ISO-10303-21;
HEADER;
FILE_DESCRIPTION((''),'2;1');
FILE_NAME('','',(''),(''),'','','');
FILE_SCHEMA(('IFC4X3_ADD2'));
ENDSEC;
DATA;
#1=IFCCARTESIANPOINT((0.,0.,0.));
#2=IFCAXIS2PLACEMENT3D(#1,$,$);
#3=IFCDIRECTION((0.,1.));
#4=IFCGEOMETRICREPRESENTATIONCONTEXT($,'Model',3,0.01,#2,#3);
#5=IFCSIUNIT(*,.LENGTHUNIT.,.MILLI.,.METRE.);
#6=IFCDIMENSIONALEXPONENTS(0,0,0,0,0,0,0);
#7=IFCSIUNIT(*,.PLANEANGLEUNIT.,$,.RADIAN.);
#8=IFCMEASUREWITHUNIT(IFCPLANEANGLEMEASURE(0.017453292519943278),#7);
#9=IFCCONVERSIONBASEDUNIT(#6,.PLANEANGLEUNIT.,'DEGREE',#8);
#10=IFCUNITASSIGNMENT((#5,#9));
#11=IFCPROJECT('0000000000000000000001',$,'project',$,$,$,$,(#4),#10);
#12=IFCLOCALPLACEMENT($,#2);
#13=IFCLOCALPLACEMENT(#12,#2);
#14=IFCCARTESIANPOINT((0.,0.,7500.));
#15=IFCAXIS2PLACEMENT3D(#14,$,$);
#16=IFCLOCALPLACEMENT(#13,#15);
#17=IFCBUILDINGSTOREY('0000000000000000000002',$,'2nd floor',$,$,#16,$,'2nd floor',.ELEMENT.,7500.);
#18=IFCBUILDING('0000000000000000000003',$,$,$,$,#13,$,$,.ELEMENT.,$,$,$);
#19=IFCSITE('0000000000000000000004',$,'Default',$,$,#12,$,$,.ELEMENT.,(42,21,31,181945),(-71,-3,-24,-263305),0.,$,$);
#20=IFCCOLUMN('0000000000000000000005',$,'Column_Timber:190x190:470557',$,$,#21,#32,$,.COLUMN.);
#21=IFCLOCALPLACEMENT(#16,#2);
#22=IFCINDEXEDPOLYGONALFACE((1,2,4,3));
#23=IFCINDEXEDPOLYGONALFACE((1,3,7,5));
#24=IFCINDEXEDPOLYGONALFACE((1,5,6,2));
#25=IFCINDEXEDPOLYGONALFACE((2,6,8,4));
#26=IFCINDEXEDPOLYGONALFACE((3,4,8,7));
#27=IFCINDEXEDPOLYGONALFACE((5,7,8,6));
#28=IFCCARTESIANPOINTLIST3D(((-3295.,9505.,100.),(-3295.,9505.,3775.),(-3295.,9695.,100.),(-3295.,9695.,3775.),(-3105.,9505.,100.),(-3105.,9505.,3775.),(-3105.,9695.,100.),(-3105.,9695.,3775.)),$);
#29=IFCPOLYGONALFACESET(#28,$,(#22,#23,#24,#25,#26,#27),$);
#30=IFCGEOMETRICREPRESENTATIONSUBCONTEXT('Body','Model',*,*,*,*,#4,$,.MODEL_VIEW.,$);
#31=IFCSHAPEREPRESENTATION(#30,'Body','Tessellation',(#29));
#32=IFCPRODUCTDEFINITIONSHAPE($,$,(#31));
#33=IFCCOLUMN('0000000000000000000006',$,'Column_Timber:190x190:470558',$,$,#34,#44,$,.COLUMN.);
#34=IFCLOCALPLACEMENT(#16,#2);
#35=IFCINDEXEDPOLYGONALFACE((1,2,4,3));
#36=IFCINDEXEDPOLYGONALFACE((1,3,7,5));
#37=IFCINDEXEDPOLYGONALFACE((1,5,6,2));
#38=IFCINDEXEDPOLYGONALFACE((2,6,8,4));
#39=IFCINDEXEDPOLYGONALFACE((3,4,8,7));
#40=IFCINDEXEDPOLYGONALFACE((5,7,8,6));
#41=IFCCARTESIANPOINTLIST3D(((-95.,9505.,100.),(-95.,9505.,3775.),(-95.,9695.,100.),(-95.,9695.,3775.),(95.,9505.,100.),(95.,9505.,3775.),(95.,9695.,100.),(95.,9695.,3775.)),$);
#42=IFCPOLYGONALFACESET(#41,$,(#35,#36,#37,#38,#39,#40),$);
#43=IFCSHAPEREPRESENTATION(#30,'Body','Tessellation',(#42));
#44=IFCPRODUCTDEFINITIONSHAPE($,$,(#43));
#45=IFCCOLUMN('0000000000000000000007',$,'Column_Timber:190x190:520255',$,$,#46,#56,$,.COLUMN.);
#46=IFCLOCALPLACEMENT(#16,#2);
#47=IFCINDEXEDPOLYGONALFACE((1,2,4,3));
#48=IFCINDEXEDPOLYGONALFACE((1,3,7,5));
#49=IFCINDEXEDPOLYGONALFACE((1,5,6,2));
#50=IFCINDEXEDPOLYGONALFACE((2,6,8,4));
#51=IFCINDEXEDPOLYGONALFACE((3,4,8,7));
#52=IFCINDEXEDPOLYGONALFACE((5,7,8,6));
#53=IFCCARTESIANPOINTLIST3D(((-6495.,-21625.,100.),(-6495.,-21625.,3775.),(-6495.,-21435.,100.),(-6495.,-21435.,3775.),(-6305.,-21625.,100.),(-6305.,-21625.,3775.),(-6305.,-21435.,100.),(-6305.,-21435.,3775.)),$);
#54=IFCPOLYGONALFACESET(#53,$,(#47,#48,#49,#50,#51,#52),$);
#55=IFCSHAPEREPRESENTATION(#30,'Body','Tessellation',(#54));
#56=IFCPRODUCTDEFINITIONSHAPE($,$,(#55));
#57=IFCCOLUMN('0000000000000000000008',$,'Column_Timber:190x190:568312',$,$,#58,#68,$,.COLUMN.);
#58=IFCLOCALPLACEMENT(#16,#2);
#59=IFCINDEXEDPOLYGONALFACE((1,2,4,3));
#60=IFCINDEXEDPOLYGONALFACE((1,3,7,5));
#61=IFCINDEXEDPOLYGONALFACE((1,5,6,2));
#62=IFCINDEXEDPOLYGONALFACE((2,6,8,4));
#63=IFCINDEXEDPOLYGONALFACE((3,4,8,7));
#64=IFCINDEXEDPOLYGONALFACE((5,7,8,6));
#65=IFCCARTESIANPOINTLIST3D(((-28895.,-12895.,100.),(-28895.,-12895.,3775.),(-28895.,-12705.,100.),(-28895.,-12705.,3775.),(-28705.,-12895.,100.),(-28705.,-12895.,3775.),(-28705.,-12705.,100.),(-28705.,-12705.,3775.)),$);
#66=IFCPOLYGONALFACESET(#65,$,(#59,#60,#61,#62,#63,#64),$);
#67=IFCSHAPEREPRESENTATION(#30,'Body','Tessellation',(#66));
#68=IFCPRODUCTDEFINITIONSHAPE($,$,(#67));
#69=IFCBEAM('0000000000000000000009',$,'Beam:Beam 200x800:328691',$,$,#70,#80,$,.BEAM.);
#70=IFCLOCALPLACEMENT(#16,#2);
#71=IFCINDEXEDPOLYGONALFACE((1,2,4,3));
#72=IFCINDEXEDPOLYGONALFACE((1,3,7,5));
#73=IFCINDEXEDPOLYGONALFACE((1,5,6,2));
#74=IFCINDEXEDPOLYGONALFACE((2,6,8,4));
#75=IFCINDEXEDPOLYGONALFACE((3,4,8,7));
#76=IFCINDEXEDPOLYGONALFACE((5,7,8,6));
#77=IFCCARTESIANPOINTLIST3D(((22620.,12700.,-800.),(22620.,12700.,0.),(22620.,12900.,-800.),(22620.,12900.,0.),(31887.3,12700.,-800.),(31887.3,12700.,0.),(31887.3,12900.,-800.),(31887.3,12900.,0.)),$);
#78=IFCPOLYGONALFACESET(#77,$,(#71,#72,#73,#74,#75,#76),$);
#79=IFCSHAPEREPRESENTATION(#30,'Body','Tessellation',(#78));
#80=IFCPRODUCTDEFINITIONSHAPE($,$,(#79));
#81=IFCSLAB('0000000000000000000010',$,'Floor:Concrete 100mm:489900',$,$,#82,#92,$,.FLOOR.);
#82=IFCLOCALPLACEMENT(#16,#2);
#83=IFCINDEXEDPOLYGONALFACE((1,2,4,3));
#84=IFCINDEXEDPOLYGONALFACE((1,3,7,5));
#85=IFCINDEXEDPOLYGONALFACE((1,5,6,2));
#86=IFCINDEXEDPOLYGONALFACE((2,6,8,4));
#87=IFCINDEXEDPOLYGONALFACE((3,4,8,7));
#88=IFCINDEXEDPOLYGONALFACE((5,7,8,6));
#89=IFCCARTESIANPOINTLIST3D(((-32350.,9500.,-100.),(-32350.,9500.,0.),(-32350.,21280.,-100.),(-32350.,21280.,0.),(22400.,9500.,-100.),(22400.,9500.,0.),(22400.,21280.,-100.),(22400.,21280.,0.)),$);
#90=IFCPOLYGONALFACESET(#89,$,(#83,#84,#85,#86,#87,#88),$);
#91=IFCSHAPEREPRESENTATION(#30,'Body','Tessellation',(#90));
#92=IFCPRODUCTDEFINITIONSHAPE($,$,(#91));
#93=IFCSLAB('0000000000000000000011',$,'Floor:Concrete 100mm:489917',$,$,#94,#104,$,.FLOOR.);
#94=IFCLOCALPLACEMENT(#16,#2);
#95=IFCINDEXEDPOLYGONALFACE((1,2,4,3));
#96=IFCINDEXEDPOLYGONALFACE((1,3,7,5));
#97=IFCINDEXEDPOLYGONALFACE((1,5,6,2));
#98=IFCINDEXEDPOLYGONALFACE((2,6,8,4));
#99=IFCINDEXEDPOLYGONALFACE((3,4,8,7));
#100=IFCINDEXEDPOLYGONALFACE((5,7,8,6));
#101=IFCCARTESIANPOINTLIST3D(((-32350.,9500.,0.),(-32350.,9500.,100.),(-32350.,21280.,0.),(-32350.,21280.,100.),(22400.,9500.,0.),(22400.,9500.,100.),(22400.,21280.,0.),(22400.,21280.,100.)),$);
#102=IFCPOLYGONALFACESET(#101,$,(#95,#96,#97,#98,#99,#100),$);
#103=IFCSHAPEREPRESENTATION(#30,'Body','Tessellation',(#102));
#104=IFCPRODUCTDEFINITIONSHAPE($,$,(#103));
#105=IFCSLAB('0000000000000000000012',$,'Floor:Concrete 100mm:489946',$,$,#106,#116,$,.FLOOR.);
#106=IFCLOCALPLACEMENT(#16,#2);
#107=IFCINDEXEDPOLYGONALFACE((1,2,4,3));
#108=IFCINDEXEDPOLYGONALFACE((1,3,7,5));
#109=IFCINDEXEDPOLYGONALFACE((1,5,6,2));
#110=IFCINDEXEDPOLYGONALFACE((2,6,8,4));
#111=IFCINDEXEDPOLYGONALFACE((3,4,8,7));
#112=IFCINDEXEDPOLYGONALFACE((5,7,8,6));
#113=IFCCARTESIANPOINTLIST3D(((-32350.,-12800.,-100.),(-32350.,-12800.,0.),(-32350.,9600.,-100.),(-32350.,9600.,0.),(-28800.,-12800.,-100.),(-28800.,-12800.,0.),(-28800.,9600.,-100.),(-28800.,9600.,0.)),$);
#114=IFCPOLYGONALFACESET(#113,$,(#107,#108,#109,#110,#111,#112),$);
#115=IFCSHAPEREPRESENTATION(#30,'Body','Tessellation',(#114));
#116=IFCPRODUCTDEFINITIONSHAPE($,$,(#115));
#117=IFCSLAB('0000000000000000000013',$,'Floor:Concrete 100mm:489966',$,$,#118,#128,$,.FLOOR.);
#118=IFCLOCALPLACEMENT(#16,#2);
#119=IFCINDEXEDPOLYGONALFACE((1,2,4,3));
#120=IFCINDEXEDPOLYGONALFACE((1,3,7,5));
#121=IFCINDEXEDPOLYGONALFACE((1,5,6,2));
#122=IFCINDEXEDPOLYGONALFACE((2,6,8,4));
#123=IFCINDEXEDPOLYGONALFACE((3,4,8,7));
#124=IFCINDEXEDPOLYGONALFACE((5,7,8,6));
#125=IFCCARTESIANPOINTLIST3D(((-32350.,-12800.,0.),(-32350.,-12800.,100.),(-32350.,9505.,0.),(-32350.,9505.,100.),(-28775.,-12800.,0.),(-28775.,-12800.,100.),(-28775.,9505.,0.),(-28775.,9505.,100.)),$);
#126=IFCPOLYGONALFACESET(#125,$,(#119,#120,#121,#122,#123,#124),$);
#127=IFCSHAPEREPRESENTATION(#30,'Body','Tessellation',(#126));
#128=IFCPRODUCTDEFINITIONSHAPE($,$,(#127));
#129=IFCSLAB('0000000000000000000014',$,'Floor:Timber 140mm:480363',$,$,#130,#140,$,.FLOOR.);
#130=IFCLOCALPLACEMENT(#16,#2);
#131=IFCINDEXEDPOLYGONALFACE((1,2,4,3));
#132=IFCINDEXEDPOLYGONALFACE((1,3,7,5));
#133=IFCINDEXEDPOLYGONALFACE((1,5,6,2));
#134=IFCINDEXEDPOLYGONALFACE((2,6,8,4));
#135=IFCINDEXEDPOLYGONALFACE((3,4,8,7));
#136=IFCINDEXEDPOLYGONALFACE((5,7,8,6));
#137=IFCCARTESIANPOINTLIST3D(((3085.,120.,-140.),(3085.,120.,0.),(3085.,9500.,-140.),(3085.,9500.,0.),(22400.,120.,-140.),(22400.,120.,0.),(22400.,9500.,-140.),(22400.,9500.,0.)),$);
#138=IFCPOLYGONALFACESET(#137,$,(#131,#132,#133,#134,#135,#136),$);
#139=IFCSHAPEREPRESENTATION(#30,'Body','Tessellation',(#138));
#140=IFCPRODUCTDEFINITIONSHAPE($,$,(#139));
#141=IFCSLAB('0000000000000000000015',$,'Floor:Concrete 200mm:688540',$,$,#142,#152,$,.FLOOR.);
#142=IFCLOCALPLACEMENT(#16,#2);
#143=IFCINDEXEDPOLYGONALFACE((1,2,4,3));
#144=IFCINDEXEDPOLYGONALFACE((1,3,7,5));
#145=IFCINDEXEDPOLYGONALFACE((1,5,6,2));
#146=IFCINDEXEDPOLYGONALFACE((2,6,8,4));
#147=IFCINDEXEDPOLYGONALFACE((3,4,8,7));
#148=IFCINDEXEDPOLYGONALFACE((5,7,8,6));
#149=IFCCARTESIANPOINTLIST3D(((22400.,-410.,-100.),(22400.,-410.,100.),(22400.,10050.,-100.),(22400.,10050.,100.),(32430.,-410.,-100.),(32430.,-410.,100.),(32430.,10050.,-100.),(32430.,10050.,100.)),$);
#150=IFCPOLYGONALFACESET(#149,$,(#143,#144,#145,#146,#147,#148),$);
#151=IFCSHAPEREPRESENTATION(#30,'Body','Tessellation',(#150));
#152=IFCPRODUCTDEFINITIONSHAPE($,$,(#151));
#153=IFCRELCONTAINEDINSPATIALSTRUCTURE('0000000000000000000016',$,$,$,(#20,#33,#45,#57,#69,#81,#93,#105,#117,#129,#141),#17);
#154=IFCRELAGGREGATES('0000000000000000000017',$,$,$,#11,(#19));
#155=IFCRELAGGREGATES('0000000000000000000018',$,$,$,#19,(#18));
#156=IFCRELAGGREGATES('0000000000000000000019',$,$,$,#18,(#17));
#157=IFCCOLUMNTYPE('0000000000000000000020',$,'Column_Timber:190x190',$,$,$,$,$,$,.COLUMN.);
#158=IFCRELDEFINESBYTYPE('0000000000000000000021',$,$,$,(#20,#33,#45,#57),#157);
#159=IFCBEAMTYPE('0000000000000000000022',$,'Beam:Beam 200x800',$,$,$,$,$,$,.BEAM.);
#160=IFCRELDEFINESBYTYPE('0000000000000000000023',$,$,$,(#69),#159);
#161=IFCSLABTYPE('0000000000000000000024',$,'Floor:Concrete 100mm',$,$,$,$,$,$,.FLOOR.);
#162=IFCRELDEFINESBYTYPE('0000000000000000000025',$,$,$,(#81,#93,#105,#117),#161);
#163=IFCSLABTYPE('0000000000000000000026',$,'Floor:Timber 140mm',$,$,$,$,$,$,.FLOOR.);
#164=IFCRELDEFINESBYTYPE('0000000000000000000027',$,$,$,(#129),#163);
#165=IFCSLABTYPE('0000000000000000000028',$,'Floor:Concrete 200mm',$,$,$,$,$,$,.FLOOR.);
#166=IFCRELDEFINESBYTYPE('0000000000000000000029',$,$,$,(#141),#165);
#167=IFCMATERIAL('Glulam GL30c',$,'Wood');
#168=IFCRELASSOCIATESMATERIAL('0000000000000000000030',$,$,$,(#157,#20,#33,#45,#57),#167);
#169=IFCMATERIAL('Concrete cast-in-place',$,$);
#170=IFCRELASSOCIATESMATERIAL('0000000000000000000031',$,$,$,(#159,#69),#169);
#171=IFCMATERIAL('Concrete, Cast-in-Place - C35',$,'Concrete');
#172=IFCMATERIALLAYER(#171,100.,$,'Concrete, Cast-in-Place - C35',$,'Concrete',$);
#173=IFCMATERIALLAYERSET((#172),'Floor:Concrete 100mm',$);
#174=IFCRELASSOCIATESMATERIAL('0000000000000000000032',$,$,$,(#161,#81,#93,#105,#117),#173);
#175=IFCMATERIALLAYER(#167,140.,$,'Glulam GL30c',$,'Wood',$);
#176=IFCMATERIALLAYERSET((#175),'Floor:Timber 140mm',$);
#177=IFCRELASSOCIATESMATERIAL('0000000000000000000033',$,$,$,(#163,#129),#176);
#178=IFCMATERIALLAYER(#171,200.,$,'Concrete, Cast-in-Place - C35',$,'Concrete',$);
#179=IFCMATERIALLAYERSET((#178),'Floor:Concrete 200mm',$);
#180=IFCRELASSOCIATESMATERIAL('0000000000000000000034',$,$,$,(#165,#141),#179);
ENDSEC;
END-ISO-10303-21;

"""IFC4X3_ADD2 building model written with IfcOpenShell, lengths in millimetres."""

from ifc_helpers import new_model, entity, si_unit, converted_unit, direction, frame, frame_2d, origin, origin_2d_with_axis, place, context, subcontext, project, spatial, rectangle, extrude, source, transform, mapped, material, layer, layer_set, layer_usage, material_profile, profile_set, profile_usage, type_object, type_shapes, element, save


model = new_model("IFC4X3_ADD2")

# Units and contexts
model_context = context("Model", 3, precision=0.01, world=origin(), true_north=direction((0.0, 1.0)))
body_context = subcontext(model_context, "Body", "Model", "MODEL_VIEW")
ifc_project = project(units=[si_unit("LENGTHUNIT", "METRE", prefix="MILLI"), converted_unit("PLANEANGLEUNIT", "DEGREE", entity("IfcPlaneAngleMeasure", 0.017453292519943278), si_unit("PLANEANGLEUNIT", "RADIAN"), dimensions=[0, 0, 0, 0, 0, 0, 0])], contexts=[model_context])

# Site, building, storey
site_placement = place(None, origin())
site = spatial("IfcSite", under=ifc_project, at=site_placement, Name="Default", CompositionType="ELEMENT", RefLatitude=(42, 21, 31, 181945), RefLongitude=(-71, -3, -24, -263305), RefElevation=0.0)
building_placement = place(site_placement, origin())
building = spatial("IfcBuilding", under=site, at=building_placement, CompositionType="ELEMENT")
storey_placement = place(building_placement, frame((0.0, 0.0, 7500.0)))
storey = spatial("IfcBuildingStorey", under=building, at=storey_placement, Name="2nd floor", LongName="2nd floor", CompositionType="ELEMENT", Elevation=7500.0)

# Columns
ifc_material_1 = material(Name="Glulam GL30c", Category="Wood")
ifc_material_profile_1 = material_profile(ifc_material_1, rectangle(XDim=190.0, YDim=190.0, at=origin_2d_with_axis()), Name="190x190")
ifc_profile_set_1 = profile_set([ifc_material_profile_1], Name="190x190")
ifc_profile_usage_1 = profile_usage(ifc_profile_set_1)
column_type = type_object("IfcColumnType", Name="Column_Timber:190x190", PredefinedType="COLUMN", material=ifc_profile_set_1)
shared_shape_1 = source(origin(), body_context, "Body", "SweptSolid", [
    extrude(rectangle(XDim=190.0, YDim=190.0, at=origin_2d_with_axis()), frame((0.0, 0.0, 7600.0), z_axis=(0.0, 0.0, 1.0), x_axis=(-1.0, 0.0, 0.0)), (0.0, 0.0, 1.0), 3675.0),
])
type_shapes(column_type, [shared_shape_1])
for number, where, name in (
    (1, (-3200.0, 9600.0, -7500.0), "Column_Timber:190x190:470557"),
    (2, (0.0, 9600.0, -7500.0), "Column_Timber:190x190:470558"),
    (3, (-6400.0, -21530.0, -7500.0), "Column_Timber:190x190:520255"),
    (4, (-28800.0, -12800.0, -7500.0), "Column_Timber:190x190:568312"),
):
    element("IfcColumn", number, at=place(storey_placement, frame(where)), inside=storey, type_object=column_type, material=ifc_profile_usage_1, Name=name, PredefinedType="COLUMN", context=body_context, shape_type="MappedRepresentation", body=[
        mapped(shared_shape_1, transform((0.0, 0.0, 0.0), scale=1.0)),
    ])

# Beam
ifc_material_2 = material(Name="Concrete cast-in-place")
ifc_material_profile_2 = material_profile(ifc_material_2, rectangle(XDim=800.0, YDim=200.0, at=frame_2d((0.0, 0.0), x_axis=(0.0, 1.0))), Name="Beam 200x800")
ifc_profile_set_2 = profile_set([ifc_material_profile_2], Name="Beam 200x800")
ifc_profile_usage_2 = profile_usage(ifc_profile_set_2, cardinal=8)
beam_type_1 = type_object("IfcBeamType", Name="Beam:Beam 200x800", PredefinedType="BEAM", material=ifc_profile_set_2)
shared_shape_2 = source(origin(), body_context, "Body", "SweptSolid", [
    extrude(rectangle(XDim=800.0, YDim=200.0, at=frame_2d((0.0, 0.0), x_axis=(1.0, 0.0))), frame((31887.3, 12800.0, 7100.0), z_axis=(-1.0, 0.0, 0.0), x_axis=(0.0, 0.0, -1.0)), (0.0, 0.0, 1.0), 9267.3),
])
type_shapes(beam_type_1, [shared_shape_2])
beam_1_placement = place(storey_placement, frame((0.0, 0.0, -7500.0)))
element("IfcBeam", 5, at=beam_1_placement, inside=storey, type_object=beam_type_1, material=ifc_profile_usage_2, Name="Beam:Beam 200x800:328691", PredefinedType="BEAM", context=body_context, shape_type="MappedRepresentation", body=[
    mapped(shared_shape_2, transform((0.0, 0.0, 0.0), scale=1.0)),
])

# Slabs
ifc_material_3 = material(Name="Concrete, Cast-in-Place - C35", Category="Concrete")
ifc_layer_1 = layer(ifc_material_3, 100.0, Name="Concrete, Cast-in-Place - C35", Category="Concrete")
ifc_layer_set_1 = layer_set([ifc_layer_1], Name="Floor:Concrete 100mm")
slab_type_1 = type_object("IfcSlabType", Name="Floor:Concrete 100mm", PredefinedType="FLOOR", material=ifc_layer_set_1)
ifc_layer_usage_1 = layer_usage(ifc_layer_set_1, "AXIS3", "POSITIVE", 0.0)
slab_1_placement = place(storey_placement, origin())
element("IfcSlab", 6, at=slab_1_placement, inside=storey, type_object=slab_type_1, material=ifc_layer_usage_1, Name="Floor:Concrete 100mm:489900", PredefinedType="FLOOR", context=body_context, shape_type="SweptSolid", body=[
    extrude(rectangle(XDim=11780.0, YDim=54750.0, at=frame_2d((0.0, 0.0), x_axis=(1.0, 0.0))), frame((-4975.0, 15390.0, 0.0), z_axis=(0.0, 0.0, -1.0), x_axis=(0.0, 1.0, 0.0)), (0.0, 0.0, 1.0), 100.0),
])
ifc_layer_usage_2 = layer_usage(ifc_layer_set_1, "AXIS3", "POSITIVE", 0.0)
slab_2_placement = place(storey_placement, origin())
element("IfcSlab", 7, at=slab_2_placement, inside=storey, type_object=slab_type_1, material=ifc_layer_usage_2, Name="Floor:Concrete 100mm:489917", PredefinedType="FLOOR", context=body_context, shape_type="SweptSolid", body=[
    extrude(rectangle(XDim=11780.0, YDim=54750.0, at=frame_2d((0.0, 0.0), x_axis=(1.0, 0.0))), frame((-4975.0, 15390.0, 100.0), z_axis=(0.0, 0.0, -1.0), x_axis=(0.0, 1.0, 0.0)), (0.0, 0.0, 1.0), 100.0),
])
ifc_layer_usage_3 = layer_usage(ifc_layer_set_1, "AXIS3", "POSITIVE", 0.0)
slab_3_placement = place(storey_placement, origin())
element("IfcSlab", 8, at=slab_3_placement, inside=storey, type_object=slab_type_1, material=ifc_layer_usage_3, Name="Floor:Concrete 100mm:489946", PredefinedType="FLOOR", context=body_context, shape_type="SweptSolid", body=[
    extrude(rectangle(XDim=22400.0, YDim=3550.0, at=origin_2d_with_axis()), frame((-30575.0, -1600.0, 0.0), z_axis=(0.0, 0.0, -1.0), x_axis=(0.0, 1.0, 0.0)), (0.0, 0.0, 1.0), 100.0),
])
ifc_layer_usage_4 = layer_usage(ifc_layer_set_1, "AXIS3", "POSITIVE", 0.0)
slab_4_placement = place(storey_placement, origin())
element("IfcSlab", 9, at=slab_4_placement, inside=storey, type_object=slab_type_1, material=ifc_layer_usage_4, Name="Floor:Concrete 100mm:489966", PredefinedType="FLOOR", context=body_context, shape_type="SweptSolid", body=[
    extrude(rectangle(XDim=22305.0, YDim=3575.0, at=frame_2d((0.0, 0.0), x_axis=(1.0, 0.0))), frame((-30562.5, -1647.5, 100.0), z_axis=(0.0, 0.0, -1.0), x_axis=(0.0, 1.0, 0.0)), (0.0, 0.0, 1.0), 100.0),
])
ifc_layer_2 = layer(ifc_material_1, 140.0, Name="Glulam GL30c", Category="Wood")
ifc_layer_set_2 = layer_set([ifc_layer_2], Name="Floor:Timber 140mm")
ifc_layer_usage_5 = layer_usage(ifc_layer_set_2, "AXIS3", "POSITIVE", 0.0)
slab_type_2 = type_object("IfcSlabType", Name="Floor:Timber 140mm", PredefinedType="FLOOR", material=ifc_layer_set_2)
slab_5_placement = place(storey_placement, origin())
element("IfcSlab", 10, at=slab_5_placement, inside=storey, type_object=slab_type_2, material=ifc_layer_usage_5, Name="Floor:Timber 140mm:480363", PredefinedType="FLOOR", context=body_context, shape_type="SweptSolid", body=[
    extrude(rectangle(XDim=9380.0, YDim=19315.0, at=origin_2d_with_axis()), frame((12742.5, 4810.0, 0.0), z_axis=(0.0, 0.0, -1.0), x_axis=(0.0, 1.0, 0.0)), (0.0, 0.0, 1.0), 140.0),
])
ifc_layer_3 = layer(ifc_material_3, 200.0, Name="Concrete, Cast-in-Place - C35", Category="Concrete")
ifc_layer_set_3 = layer_set([ifc_layer_3], Name="Floor:Concrete 200mm")
ifc_layer_usage_6 = layer_usage(ifc_layer_set_3, "AXIS3", "POSITIVE", 0.0)
slab_type_3 = type_object("IfcSlabType", Name="Floor:Concrete 200mm", PredefinedType="FLOOR", material=ifc_layer_set_3)
slab_6_placement = place(storey_placement, origin())
element("IfcSlab", 11, at=slab_6_placement, inside=storey, type_object=slab_type_3, material=ifc_layer_usage_6, Name="Floor:Concrete 200mm:688540", PredefinedType="FLOOR", context=body_context, shape_type="SweptSolid", body=[
    extrude(rectangle(XDim=10460.0, YDim=10030.0, at=frame_2d((0.0, 0.0), x_axis=(1.0, 0.0))), frame((27415.0, 4820.0, 100.0), z_axis=(0.0, 0.0, -1.0), x_axis=(0.0, 1.0, 0.0)), (0.0, 0.0, 1.0), 200.0),
])

save(model, "model.ifc")
